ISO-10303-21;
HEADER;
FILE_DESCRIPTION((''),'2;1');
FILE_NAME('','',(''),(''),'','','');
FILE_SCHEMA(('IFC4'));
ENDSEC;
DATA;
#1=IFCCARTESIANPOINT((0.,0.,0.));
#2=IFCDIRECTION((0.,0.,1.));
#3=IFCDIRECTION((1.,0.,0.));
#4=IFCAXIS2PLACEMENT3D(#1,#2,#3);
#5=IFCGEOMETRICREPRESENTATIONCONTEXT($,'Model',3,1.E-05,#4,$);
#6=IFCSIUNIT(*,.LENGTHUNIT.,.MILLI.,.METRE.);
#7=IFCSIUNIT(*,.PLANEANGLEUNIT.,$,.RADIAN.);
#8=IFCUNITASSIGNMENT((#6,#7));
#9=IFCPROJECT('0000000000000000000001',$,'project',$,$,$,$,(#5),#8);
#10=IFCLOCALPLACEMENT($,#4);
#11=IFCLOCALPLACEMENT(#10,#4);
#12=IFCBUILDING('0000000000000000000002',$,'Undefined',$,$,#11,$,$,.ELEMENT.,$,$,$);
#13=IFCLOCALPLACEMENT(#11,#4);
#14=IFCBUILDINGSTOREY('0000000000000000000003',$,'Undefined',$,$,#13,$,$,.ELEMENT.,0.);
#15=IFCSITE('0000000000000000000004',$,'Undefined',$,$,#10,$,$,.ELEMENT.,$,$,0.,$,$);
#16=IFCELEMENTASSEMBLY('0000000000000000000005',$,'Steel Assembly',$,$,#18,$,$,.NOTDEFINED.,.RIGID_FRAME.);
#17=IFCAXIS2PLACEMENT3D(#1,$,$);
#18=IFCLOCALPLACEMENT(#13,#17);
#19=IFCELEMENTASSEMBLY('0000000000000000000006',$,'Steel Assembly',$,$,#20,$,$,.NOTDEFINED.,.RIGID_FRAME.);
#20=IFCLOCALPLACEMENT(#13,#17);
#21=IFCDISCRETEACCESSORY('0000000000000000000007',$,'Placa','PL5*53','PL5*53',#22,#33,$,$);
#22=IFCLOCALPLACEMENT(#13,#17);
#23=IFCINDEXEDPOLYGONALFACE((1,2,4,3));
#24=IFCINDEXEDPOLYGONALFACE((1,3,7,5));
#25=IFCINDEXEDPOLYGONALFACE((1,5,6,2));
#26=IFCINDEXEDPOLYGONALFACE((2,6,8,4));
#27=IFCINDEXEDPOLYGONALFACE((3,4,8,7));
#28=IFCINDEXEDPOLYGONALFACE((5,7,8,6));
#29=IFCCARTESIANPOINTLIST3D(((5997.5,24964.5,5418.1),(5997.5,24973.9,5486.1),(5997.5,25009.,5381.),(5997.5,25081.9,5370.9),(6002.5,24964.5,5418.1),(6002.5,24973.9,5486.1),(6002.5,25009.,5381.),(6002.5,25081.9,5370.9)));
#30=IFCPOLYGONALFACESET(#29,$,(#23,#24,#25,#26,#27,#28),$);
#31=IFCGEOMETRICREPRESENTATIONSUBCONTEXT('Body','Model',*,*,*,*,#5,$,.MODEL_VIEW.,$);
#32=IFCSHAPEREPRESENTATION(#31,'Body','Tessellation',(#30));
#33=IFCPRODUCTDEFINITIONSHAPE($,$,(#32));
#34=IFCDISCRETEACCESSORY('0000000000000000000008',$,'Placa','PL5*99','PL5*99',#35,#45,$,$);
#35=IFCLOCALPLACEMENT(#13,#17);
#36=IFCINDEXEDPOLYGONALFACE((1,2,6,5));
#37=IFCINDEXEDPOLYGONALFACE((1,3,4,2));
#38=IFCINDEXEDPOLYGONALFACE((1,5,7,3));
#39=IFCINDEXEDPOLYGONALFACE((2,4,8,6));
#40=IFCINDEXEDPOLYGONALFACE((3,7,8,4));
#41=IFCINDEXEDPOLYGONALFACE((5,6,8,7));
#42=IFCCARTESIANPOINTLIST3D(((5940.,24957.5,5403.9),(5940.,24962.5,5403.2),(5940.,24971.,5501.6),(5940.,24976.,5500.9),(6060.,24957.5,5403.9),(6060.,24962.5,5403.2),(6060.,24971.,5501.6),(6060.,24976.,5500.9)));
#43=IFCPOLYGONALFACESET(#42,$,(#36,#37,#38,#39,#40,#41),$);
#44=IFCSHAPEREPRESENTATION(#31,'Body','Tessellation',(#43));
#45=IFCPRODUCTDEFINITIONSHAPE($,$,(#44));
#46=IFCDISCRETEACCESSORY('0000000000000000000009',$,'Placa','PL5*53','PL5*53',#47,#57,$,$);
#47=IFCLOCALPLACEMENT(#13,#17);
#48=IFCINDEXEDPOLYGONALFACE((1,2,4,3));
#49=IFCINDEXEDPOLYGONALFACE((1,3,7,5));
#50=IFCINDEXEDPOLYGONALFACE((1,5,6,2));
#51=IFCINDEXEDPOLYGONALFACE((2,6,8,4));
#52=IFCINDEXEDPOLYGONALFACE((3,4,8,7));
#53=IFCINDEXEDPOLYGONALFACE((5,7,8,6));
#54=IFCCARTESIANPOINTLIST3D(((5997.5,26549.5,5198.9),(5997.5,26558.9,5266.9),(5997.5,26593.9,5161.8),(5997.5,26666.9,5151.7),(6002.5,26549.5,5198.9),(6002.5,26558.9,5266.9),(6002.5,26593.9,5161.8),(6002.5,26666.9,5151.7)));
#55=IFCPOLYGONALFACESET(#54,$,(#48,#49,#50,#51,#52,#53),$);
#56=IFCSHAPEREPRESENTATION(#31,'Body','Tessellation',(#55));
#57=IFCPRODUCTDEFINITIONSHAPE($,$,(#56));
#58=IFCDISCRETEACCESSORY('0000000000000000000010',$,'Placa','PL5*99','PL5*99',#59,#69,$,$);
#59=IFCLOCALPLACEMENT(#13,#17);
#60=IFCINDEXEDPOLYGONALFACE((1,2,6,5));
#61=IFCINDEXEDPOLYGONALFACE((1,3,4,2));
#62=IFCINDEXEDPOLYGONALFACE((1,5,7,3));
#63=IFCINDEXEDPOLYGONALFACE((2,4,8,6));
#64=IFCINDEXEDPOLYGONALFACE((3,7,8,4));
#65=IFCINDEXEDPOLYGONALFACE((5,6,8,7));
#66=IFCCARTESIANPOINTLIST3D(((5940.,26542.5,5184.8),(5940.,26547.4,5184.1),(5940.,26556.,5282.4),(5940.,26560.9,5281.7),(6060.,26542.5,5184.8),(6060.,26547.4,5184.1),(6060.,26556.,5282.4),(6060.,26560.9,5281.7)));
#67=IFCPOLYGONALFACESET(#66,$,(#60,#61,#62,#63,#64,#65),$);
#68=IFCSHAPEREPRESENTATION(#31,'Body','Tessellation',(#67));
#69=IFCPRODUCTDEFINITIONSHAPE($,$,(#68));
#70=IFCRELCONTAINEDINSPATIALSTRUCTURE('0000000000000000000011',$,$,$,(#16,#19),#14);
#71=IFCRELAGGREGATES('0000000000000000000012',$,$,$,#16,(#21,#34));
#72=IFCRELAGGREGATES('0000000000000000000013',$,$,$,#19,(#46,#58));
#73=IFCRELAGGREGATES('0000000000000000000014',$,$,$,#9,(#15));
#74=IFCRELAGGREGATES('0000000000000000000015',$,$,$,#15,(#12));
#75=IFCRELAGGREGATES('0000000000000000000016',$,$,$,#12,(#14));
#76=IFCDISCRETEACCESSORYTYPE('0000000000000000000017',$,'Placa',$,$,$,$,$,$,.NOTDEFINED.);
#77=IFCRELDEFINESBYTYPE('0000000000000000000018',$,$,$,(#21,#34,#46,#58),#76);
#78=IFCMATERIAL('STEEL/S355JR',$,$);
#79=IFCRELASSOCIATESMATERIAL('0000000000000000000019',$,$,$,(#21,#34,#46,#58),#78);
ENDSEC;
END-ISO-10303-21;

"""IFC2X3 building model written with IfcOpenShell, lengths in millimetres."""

from ifc_helpers import new_model, si_unit, frame, origin_with_axes, place, context, subcontext, project, spatial, polyline, outline, extrude, material, type_object, element, aggregate, save


model = new_model("IFC2X3")

# Units and contexts
model_context = context("Model", 3, precision=1e-05, world=origin_with_axes())
body_context = subcontext(model_context, "Body", "Model", "MODEL_VIEW")
ifc_project = project(units=[si_unit("LENGTHUNIT", "METRE", prefix="MILLI"), si_unit("PLANEANGLEUNIT", "RADIAN")], contexts=[model_context])

# Site, building, storey
site_placement = place(None, origin_with_axes())
site = spatial("IfcSite", under=ifc_project, at=site_placement, Name="Undefined", CompositionType="ELEMENT", RefElevation=0.0)
building_placement = place(site_placement, origin_with_axes())
building = spatial("IfcBuilding", under=site, at=building_placement, Name="Undefined", CompositionType="ELEMENT")
storey_placement = place(building_placement, origin_with_axes())
storey = spatial("IfcBuildingStorey", under=building, at=storey_placement, Name="Undefined", CompositionType="ELEMENT", Elevation=0.0)

# Shared definitions
ifc_material_1 = material(Name="STEEL/S355JR")

# Element assemblies
assembly_1_placement = place(storey_placement, origin_with_axes())
assembly_1 = element("IfcElementAssembly", 1, at=assembly_1_placement, inside=storey, Name="Steel Assembly", AssemblyPlace="NOTDEFINED", PredefinedType="RIGID_FRAME")
assembly_2_placement = place(storey_placement, origin_with_axes())
assembly_2 = element("IfcElementAssembly", 2, at=assembly_2_placement, inside=storey, Name="Steel Assembly", AssemblyPlace="NOTDEFINED", PredefinedType="RIGID_FRAME")

# Discrete accessories
discrete_accessory_type_1 = type_object("IfcDiscreteAccessoryType", Name="Placa")
discrete_accessory_1_placement = place(assembly_1_placement, frame((6000.0, 24973.9, 5486.1), z_axis=(-1.0, 0.0, 0.0), x_axis=(0.0, 0.684057, -0.729429)))
discrete_accessory_1 = element("IfcDiscreteAccessory", 3, at=discrete_accessory_1_placement, type_object=discrete_accessory_type_1, material=ifc_material_1, Name="Placa", Description="PL5*53", ObjectType="PL5*53", context=body_context, shape_type="SweptSolid", body=[
    extrude(outline(polyline([(0.0, 0.0), (157.9, 0.0), (100.7, 46.3), (43.1, 53.3), (0.0, 0.0)])), frame((0.0, 0.0, -2.5), z_axis=(0.0, 0.0, 1.0), x_axis=(1.0, 0.0, 0.0)), (0.0, 0.0, 1.0), 5.0),
])
discrete_accessory_2_placement = place(assembly_1_placement, frame((5940.0, 24960.0, 5403.6), z_axis=(0.0, 0.990592, -0.136849), x_axis=(0.0, 0.136849, 0.990592)))
discrete_accessory_2 = element("IfcDiscreteAccessory", 4, at=discrete_accessory_2_placement, type_object=discrete_accessory_type_1, material=ifc_material_1, Name="Placa", Description="PL5*99", ObjectType="PL5*99", context=body_context, shape_type="SweptSolid", body=[
    extrude(outline(polyline([(0.0, 0.0), (98.6, 0.0), (98.6, 120.0), (0.0, 120.0), (0.0, 0.0)])), frame((0.0, 0.0, -2.5), z_axis=(0.0, 0.0, 1.0), x_axis=(1.0, 0.0, 0.0)), (0.0, 0.0, 1.0), 5.0),
])
discrete_accessory_3_placement = place(assembly_2_placement, frame((6000.0, 26558.9, 5266.9), z_axis=(-1.0, 0.0, 0.0), x_axis=(0.0, 0.684057, -0.729429)))
discrete_accessory_3 = element("IfcDiscreteAccessory", 5, at=discrete_accessory_3_placement, type_object=discrete_accessory_type_1, material=ifc_material_1, Name="Placa", Description="PL5*53", ObjectType="PL5*53", context=body_context, shape_type="SweptSolid", body=[
    extrude(outline(polyline([(0.0, 0.0), (157.9, 0.0), (100.7, 46.3), (43.1, 53.3), (0.0, 0.0)])), frame((0.0, 0.0, -2.5), z_axis=(0.0, 0.0, 1.0), x_axis=(1.0, 0.0, 0.0)), (0.0, 0.0, 1.0), 5.0),
])
discrete_accessory_4_placement = place(assembly_2_placement, frame((5940.0, 26544.9, 5184.4), z_axis=(0.0, 0.990592, -0.136849), x_axis=(0.0, 0.136849, 0.990592)))
discrete_accessory_4 = element("IfcDiscreteAccessory", 6, at=discrete_accessory_4_placement, type_object=discrete_accessory_type_1, material=ifc_material_1, Name="Placa", Description="PL5*99", ObjectType="PL5*99", context=body_context, shape_type="SweptSolid", body=[
    extrude(outline(polyline([(0.0, 0.0), (98.6, 0.0), (98.6, 120.0), (0.0, 120.0), (0.0, 0.0)])), frame((0.0, 0.0, -2.5), z_axis=(0.0, 0.0, 1.0), x_axis=(1.0, 0.0, 0.0)), (0.0, 0.0, 1.0), 5.0),
])

aggregate(assembly_1, [discrete_accessory_1, discrete_accessory_2])
aggregate(assembly_2, [discrete_accessory_3, discrete_accessory_4])

save(model, "model.ifc")
